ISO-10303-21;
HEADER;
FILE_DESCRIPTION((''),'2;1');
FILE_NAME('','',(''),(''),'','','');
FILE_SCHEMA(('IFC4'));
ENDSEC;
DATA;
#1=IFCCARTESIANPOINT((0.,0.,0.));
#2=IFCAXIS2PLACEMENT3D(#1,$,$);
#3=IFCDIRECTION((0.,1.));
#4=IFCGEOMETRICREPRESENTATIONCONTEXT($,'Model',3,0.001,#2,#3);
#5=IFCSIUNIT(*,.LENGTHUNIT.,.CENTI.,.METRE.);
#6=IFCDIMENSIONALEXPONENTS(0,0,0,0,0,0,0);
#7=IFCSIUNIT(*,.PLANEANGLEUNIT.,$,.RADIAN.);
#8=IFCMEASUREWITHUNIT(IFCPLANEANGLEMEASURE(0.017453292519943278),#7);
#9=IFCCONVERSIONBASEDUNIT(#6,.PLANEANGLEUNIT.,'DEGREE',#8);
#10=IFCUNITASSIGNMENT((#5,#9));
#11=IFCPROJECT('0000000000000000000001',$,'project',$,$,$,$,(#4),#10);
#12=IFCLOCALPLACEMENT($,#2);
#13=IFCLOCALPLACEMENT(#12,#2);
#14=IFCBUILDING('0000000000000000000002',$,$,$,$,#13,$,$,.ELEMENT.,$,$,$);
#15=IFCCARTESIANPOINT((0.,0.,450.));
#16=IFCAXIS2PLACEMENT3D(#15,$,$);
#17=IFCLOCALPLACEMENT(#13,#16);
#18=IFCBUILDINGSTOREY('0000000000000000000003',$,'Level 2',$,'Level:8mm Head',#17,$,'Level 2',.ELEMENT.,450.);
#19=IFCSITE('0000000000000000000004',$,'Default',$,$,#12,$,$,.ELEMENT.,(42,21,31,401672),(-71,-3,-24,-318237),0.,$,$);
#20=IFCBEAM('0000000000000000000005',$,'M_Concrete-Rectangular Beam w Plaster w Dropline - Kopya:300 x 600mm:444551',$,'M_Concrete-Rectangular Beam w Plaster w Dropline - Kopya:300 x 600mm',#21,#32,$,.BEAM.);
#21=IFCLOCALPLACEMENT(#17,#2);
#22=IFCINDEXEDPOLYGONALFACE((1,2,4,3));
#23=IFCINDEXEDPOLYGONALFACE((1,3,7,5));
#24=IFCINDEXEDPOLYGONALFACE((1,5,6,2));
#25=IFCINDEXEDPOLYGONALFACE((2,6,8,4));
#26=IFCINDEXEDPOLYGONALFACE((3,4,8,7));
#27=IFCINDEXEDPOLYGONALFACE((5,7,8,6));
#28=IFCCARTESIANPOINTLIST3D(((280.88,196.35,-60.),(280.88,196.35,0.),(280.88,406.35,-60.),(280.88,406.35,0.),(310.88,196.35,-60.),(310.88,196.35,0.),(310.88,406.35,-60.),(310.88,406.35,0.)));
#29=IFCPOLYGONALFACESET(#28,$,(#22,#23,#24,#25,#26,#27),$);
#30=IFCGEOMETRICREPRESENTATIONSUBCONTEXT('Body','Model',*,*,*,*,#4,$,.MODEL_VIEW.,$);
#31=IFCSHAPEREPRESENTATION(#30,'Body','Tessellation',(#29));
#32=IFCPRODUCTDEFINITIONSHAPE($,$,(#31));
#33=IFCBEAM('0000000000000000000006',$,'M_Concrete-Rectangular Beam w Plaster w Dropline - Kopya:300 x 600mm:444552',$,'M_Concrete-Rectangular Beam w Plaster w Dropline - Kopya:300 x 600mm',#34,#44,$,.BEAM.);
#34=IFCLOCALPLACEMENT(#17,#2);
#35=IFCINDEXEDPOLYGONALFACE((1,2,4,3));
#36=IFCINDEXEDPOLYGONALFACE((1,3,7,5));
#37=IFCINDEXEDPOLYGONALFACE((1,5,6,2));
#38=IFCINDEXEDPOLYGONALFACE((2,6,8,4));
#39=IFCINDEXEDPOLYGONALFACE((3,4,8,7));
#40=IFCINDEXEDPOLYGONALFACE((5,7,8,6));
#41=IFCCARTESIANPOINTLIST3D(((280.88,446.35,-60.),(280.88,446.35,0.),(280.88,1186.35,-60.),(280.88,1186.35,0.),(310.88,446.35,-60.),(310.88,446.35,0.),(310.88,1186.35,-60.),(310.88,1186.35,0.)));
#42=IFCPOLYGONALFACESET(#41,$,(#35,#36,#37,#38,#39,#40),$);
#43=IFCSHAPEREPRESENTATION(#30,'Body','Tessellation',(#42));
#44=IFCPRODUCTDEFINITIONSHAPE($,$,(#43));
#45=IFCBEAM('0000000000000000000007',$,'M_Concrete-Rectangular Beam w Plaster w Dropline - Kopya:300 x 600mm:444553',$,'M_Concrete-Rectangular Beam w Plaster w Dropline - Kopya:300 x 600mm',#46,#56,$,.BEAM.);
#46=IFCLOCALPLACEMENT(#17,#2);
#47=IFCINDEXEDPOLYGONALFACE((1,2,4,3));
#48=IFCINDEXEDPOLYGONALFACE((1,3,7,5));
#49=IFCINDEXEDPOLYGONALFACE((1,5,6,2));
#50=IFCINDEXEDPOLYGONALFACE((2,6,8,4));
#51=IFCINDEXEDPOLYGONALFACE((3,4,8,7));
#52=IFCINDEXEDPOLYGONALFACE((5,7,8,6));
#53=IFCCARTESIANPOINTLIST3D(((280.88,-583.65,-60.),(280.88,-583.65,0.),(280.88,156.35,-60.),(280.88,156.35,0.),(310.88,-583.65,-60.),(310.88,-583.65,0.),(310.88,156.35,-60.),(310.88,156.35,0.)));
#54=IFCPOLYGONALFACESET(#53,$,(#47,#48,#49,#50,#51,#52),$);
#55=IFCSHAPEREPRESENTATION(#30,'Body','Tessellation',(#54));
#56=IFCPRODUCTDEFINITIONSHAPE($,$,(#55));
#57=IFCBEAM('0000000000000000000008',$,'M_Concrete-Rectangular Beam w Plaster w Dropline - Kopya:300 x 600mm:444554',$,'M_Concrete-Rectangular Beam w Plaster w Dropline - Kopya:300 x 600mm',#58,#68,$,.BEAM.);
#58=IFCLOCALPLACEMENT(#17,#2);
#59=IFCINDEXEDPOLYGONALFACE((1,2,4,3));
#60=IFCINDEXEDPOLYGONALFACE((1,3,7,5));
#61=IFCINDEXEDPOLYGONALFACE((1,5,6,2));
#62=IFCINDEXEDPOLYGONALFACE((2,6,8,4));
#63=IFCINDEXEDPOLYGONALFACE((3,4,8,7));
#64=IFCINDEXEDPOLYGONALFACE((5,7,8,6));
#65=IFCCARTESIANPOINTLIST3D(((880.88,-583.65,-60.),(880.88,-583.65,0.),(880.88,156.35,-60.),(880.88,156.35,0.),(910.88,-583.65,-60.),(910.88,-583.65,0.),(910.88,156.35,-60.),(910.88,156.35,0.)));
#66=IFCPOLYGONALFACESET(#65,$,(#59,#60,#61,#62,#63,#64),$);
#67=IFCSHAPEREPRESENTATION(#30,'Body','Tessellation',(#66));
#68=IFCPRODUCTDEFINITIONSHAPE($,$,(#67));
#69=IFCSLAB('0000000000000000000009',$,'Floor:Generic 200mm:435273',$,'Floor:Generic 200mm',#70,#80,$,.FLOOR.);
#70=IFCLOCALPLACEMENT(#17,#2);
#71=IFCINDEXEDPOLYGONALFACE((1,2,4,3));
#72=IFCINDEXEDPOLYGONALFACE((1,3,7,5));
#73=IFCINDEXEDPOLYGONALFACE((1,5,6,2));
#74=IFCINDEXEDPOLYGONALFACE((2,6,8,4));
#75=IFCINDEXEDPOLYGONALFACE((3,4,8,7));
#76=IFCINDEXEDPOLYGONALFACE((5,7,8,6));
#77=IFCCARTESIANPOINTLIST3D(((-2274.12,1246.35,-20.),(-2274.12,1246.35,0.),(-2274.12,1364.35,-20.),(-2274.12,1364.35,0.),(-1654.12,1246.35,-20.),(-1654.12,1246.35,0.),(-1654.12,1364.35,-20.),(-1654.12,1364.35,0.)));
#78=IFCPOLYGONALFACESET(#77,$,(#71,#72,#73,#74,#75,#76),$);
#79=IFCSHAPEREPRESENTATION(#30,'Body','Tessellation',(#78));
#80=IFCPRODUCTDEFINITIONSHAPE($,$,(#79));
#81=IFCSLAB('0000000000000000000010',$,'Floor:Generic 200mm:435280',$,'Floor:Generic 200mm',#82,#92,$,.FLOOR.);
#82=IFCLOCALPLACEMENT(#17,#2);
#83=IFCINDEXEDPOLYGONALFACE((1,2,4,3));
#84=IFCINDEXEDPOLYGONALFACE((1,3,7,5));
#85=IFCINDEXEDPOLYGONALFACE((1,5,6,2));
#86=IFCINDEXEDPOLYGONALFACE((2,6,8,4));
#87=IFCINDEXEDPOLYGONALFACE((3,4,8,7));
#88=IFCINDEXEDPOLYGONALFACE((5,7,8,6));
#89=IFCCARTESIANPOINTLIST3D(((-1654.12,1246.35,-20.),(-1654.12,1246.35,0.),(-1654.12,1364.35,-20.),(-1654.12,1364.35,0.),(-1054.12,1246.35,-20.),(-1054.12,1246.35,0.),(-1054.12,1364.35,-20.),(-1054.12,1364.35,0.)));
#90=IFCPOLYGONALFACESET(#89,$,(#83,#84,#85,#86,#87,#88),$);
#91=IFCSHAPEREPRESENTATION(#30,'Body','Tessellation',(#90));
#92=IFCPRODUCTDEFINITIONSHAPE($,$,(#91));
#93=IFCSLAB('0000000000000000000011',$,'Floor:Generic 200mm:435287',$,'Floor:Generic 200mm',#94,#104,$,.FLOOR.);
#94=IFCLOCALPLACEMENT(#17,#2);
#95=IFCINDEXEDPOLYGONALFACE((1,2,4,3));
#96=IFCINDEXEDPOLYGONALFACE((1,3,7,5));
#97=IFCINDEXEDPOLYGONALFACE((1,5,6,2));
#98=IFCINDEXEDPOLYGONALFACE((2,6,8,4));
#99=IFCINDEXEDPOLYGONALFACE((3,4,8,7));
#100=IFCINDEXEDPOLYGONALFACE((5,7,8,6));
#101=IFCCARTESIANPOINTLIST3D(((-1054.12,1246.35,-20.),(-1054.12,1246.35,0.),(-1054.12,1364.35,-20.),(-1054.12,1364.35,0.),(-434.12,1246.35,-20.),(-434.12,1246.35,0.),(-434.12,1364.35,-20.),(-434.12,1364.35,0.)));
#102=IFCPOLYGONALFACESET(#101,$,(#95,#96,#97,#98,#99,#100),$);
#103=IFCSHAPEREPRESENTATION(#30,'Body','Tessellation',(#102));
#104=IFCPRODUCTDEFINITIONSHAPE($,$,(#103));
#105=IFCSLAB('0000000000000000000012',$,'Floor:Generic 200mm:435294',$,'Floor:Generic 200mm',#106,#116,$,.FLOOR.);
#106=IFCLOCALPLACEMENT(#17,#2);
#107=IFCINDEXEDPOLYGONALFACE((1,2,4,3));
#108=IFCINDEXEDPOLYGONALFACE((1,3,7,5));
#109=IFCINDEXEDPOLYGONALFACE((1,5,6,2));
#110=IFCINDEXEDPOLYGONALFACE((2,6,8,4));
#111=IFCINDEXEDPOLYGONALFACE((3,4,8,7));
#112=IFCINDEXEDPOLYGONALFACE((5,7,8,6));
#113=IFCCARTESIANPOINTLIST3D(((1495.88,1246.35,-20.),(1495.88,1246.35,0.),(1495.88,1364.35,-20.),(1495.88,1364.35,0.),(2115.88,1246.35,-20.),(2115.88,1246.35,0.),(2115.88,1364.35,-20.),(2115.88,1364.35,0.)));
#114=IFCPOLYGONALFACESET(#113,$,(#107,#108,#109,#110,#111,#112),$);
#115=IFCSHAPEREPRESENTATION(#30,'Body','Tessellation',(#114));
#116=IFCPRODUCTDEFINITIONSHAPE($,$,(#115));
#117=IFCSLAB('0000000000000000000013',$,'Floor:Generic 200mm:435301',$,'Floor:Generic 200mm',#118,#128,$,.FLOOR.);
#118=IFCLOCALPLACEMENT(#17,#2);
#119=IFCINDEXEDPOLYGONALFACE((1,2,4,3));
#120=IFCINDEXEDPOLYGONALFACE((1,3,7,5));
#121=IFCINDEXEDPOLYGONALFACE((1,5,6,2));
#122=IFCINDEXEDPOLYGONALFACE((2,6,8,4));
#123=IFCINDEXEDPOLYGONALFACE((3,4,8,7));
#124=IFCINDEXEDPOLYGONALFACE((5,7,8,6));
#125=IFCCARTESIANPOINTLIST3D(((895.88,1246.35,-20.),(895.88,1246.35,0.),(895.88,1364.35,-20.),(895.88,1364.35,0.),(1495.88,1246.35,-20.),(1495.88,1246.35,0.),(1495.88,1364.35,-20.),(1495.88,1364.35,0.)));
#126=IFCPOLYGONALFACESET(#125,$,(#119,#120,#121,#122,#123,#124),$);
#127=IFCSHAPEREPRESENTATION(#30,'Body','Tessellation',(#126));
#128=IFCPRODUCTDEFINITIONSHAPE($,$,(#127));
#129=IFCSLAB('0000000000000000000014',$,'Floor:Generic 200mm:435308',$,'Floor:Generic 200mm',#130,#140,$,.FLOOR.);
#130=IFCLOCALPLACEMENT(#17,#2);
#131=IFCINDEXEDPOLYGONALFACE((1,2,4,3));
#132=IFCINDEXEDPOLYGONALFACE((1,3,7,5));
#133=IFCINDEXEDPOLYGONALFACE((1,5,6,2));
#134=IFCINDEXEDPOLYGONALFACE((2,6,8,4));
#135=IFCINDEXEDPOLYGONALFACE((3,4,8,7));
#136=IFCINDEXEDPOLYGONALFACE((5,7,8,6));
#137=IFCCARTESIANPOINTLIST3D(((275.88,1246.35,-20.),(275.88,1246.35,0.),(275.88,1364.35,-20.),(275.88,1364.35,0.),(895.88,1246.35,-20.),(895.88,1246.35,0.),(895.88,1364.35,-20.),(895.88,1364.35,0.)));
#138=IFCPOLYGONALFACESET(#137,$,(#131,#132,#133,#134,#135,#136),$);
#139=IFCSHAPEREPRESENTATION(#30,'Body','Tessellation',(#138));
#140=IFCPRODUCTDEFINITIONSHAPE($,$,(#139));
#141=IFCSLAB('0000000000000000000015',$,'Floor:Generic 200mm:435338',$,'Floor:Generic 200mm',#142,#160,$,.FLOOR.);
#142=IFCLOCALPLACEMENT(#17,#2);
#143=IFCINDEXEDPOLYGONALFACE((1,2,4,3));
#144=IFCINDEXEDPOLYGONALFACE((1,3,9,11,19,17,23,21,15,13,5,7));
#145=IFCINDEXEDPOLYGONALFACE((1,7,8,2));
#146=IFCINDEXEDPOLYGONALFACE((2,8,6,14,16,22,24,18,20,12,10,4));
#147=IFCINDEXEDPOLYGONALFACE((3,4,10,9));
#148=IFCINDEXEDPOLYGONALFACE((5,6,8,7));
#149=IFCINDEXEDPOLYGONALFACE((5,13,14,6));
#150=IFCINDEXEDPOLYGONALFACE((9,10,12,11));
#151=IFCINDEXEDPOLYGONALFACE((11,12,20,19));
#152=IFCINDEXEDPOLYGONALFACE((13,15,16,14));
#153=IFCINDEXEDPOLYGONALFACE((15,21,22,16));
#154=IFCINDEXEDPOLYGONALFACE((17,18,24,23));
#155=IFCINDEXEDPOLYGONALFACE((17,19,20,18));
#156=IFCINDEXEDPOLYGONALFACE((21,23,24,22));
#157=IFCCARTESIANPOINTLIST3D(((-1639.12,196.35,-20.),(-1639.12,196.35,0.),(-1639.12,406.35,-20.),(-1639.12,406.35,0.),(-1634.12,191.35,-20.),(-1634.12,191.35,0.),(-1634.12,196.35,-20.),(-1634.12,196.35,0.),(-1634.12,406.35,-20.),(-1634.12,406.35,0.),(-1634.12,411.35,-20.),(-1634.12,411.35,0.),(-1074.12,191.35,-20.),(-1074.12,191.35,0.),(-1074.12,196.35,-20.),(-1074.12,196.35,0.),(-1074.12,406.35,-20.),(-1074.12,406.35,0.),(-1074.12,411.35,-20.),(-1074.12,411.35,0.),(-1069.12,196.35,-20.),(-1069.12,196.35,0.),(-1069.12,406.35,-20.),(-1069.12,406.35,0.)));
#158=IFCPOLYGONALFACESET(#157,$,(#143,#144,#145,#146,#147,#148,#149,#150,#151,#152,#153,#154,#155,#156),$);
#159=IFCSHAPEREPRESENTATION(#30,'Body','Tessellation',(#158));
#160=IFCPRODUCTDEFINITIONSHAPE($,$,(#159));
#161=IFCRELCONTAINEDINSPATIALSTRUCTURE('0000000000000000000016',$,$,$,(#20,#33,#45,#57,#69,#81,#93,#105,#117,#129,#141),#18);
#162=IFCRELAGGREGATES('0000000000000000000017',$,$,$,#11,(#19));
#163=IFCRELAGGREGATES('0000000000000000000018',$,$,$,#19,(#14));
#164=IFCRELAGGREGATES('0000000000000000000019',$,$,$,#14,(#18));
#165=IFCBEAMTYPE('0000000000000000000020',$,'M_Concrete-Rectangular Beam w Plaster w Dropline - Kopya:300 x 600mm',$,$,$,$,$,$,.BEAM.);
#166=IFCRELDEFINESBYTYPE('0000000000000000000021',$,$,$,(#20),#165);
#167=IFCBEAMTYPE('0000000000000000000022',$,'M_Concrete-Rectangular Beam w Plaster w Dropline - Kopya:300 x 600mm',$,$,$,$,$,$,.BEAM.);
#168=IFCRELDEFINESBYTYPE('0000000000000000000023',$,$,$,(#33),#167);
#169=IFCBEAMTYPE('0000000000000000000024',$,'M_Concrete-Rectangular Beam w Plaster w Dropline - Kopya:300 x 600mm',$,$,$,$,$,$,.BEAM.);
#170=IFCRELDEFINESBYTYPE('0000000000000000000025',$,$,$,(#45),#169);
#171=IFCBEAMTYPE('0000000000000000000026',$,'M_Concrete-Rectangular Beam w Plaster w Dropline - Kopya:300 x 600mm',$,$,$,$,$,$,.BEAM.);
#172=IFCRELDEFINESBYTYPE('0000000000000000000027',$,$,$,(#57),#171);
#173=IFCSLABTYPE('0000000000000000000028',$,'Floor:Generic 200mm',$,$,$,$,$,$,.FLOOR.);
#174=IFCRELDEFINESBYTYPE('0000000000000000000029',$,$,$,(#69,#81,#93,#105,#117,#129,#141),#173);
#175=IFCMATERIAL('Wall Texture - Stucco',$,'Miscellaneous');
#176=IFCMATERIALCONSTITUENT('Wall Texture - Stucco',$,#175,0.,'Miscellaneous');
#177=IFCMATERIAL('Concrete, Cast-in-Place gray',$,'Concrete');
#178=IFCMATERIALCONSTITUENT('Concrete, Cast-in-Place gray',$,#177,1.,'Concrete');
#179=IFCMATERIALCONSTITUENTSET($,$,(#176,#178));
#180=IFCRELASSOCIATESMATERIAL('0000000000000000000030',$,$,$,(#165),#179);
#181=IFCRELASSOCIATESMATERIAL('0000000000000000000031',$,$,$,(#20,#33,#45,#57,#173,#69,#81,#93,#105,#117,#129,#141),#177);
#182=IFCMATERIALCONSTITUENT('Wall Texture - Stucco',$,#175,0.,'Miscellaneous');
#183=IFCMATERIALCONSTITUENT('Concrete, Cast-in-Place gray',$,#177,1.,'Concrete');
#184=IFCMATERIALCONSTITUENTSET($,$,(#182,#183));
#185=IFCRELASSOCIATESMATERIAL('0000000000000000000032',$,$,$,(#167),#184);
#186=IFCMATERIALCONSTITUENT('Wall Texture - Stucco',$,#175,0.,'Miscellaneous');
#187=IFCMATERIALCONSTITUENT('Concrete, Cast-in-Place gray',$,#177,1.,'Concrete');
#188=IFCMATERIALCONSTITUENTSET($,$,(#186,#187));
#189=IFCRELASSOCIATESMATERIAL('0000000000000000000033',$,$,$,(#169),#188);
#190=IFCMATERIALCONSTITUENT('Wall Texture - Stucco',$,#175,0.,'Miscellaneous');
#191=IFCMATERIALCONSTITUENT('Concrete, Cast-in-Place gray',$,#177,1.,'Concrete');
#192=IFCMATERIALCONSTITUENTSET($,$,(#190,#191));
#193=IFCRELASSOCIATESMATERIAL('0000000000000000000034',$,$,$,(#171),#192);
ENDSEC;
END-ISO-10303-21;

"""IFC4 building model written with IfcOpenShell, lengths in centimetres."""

from ifc_helpers import new_model, entity, si_unit, converted_unit, direction, frame, origin, place, context, subcontext, project, spatial, indexed_curve, outline, extrude, source, transform, mapped, material, constituent, constituent_set, type_object, type_shapes, element, save


model = new_model("IFC4")

# Units and contexts
model_context = context("Model", 3, precision=0.001, world=origin(), true_north=direction((0.0, 1.0)))
body_context = subcontext(model_context, "Body", "Model", "MODEL_VIEW")
ifc_project = project(units=[si_unit("LENGTHUNIT", "METRE", prefix="CENTI"), converted_unit("PLANEANGLEUNIT", "DEGREE", entity("IfcPlaneAngleMeasure", 0.017453292519943278), si_unit("PLANEANGLEUNIT", "RADIAN"), dimensions=[0, 0, 0, 0, 0, 0, 0])], contexts=[model_context])

# Site, building, storey
site_placement = place(None, origin())
site = spatial("IfcSite", under=ifc_project, at=site_placement, Name="Default", CompositionType="ELEMENT", RefLatitude=(42, 21, 31, 401672), RefLongitude=(-71, -3, -24, -318237), RefElevation=0.0)
building_placement = place(site_placement, origin())
building = spatial("IfcBuilding", under=site, at=building_placement, CompositionType="ELEMENT")
storey_placement = place(building_placement, frame((0.0, 0.0, 450.0)))
storey = spatial("IfcBuildingStorey", under=building, at=storey_placement, Name="Level 2", ObjectType="Level:8mm Head", LongName="Level 2", CompositionType="ELEMENT", Elevation=450.0)

# Beams
ifc_material_1 = material(Name="Concrete, Cast-in-Place gray", Category="Concrete")
ifc_material_2 = material(Name="Wall Texture - Stucco", Category="Miscellaneous")
ifc_constituent_1 = constituent(ifc_material_2, Name="Wall Texture - Stucco", Category="Miscellaneous", fraction=0.0)
ifc_constituent_2 = constituent(ifc_material_1, Name="Concrete, Cast-in-Place gray", Category="Concrete", fraction=1.0)
ifc_constituent_set_1 = constituent_set(constituents=[ifc_constituent_1, ifc_constituent_2])
beam_type_1 = type_object("IfcBeamType", Name="M_Concrete-Rectangular Beam w Plaster w Dropline - Kopya:300 x 600mm", PredefinedType="BEAM", material=ifc_constituent_set_1)
shared_shape_1 = source(origin(), body_context, "Body", "SweptSolid", [
    extrude(outline(indexed_curve([(-15.0, -30.0), (15.0, -30.0), (15.0, 30.0), (-15.0, 30.0), (-15.0, -30.0)], self_intersect=False)), frame((295.88, 406.35, 420.0), z_axis=(0.0, -1.0, 0.0), x_axis=(-1.0, 0.0, 0.0)), (0.0, 0.0, 1.0), 210.0),
])
type_shapes(beam_type_1, [shared_shape_1])
beam_1_placement = place(storey_placement, frame((0.0, 0.0, -450.0)))
element("IfcBeam", 1, at=beam_1_placement, inside=storey, type_object=beam_type_1, material=ifc_material_1, Name="M_Concrete-Rectangular Beam w Plaster w Dropline - Kopya:300 x 600mm:444551", ObjectType="M_Concrete-Rectangular Beam w Plaster w Dropline - Kopya:300 x 600mm", PredefinedType="BEAM", context=body_context, shape_type="MappedRepresentation", body=[
    mapped(shared_shape_1, transform((0.0, 0.0, 0.0), scale=1.0)),
])
ifc_constituent_3 = constituent(ifc_material_2, Name="Wall Texture - Stucco", Category="Miscellaneous", fraction=0.0)
ifc_constituent_4 = constituent(ifc_material_1, Name="Concrete, Cast-in-Place gray", Category="Concrete", fraction=1.0)
ifc_constituent_set_2 = constituent_set(constituents=[ifc_constituent_3, ifc_constituent_4])
beam_type_2 = type_object("IfcBeamType", Name="M_Concrete-Rectangular Beam w Plaster w Dropline - Kopya:300 x 600mm", PredefinedType="BEAM", material=ifc_constituent_set_2)
shared_shape_2 = source(origin(), body_context, "Body", "SweptSolid", [
    extrude(outline(indexed_curve([(-15.0, -30.0), (15.0, -30.0), (15.0, 30.0), (-15.0, 30.0), (-15.0, -30.0)], self_intersect=False)), frame((295.88, 446.35, 420.0), z_axis=(0.0, 1.0, 0.0), x_axis=(-1.0, 0.0, 0.0)), (0.0, 0.0, 1.0), 740.0),
])
type_shapes(beam_type_2, [shared_shape_2])
beam_2_placement = place(storey_placement, frame((0.0, 0.0, -450.0)))
element("IfcBeam", 2, at=beam_2_placement, inside=storey, type_object=beam_type_2, material=ifc_material_1, Name="M_Concrete-Rectangular Beam w Plaster w Dropline - Kopya:300 x 600mm:444552", ObjectType="M_Concrete-Rectangular Beam w Plaster w Dropline - Kopya:300 x 600mm", PredefinedType="BEAM", context=body_context, shape_type="MappedRepresentation", body=[
    mapped(shared_shape_2, transform((0.0, 0.0, 0.0), scale=1.0)),
])
ifc_constituent_5 = constituent(ifc_material_2, Name="Wall Texture - Stucco", Category="Miscellaneous", fraction=0.0)
ifc_constituent_6 = constituent(ifc_material_1, Name="Concrete, Cast-in-Place gray", Category="Concrete", fraction=1.0)
ifc_constituent_set_3 = constituent_set(constituents=[ifc_constituent_5, ifc_constituent_6])
beam_type_3 = type_object("IfcBeamType", Name="M_Concrete-Rectangular Beam w Plaster w Dropline - Kopya:300 x 600mm", PredefinedType="BEAM", material=ifc_constituent_set_3)
shared_shape_3 = source(origin(), body_context, "Body", "SweptSolid", [
    extrude(outline(indexed_curve([(-15.0, -30.0), (15.0, -30.0), (15.0, 30.0), (-15.0, 30.0), (-15.0, -30.0)], self_intersect=False)), frame((295.88, 156.35, 420.0), z_axis=(0.0, -1.0, 0.0), x_axis=(-1.0, 0.0, 0.0)), (0.0, 0.0, 1.0), 740.0),
])
type_shapes(beam_type_3, [shared_shape_3])
beam_3_placement = place(storey_placement, frame((0.0, 0.0, -450.0)))
element("IfcBeam", 3, at=beam_3_placement, inside=storey, type_object=beam_type_3, material=ifc_material_1, Name="M_Concrete-Rectangular Beam w Plaster w Dropline - Kopya:300 x 600mm:444553", ObjectType="M_Concrete-Rectangular Beam w Plaster w Dropline - Kopya:300 x 600mm", PredefinedType="BEAM", context=body_context, shape_type="MappedRepresentation", body=[
    mapped(shared_shape_3, transform((0.0, 0.0, 0.0), scale=1.0)),
])
ifc_constituent_7 = constituent(ifc_material_2, Name="Wall Texture - Stucco", Category="Miscellaneous", fraction=0.0)
ifc_constituent_8 = constituent(ifc_material_1, Name="Concrete, Cast-in-Place gray", Category="Concrete", fraction=1.0)
ifc_constituent_set_4 = constituent_set(constituents=[ifc_constituent_7, ifc_constituent_8])
beam_type_4 = type_object("IfcBeamType", Name="M_Concrete-Rectangular Beam w Plaster w Dropline - Kopya:300 x 600mm", PredefinedType="BEAM", material=ifc_constituent_set_4)
shared_shape_4 = source(origin(), body_context, "Body", "SweptSolid", [
    extrude(outline(indexed_curve([(-15.0, -30.0), (15.0, -30.0), (15.0, 30.0), (-15.0, 30.0), (-15.0, -30.0)], self_intersect=False)), frame((895.88, -583.65, 420.0), z_axis=(0.0, 1.0, 0.0), x_axis=(-1.0, 0.0, 0.0)), (0.0, 0.0, 1.0), 740.0),
])
type_shapes(beam_type_4, [shared_shape_4])
beam_4_placement = place(storey_placement, frame((0.0, 0.0, -450.0)))
element("IfcBeam", 4, at=beam_4_placement, inside=storey, type_object=beam_type_4, material=ifc_material_1, Name="M_Concrete-Rectangular Beam w Plaster w Dropline - Kopya:300 x 600mm:444554", ObjectType="M_Concrete-Rectangular Beam w Plaster w Dropline - Kopya:300 x 600mm", PredefinedType="BEAM", context=body_context, shape_type="MappedRepresentation", body=[
    mapped(shared_shape_4, transform((0.0, 0.0, 0.0), scale=1.0)),
])

# Shared definitions
slab_type = type_object("IfcSlabType", Name="Floor:Generic 200mm", PredefinedType="FLOOR", material=ifc_material_1)

# Slabs
slab_1_placement = place(storey_placement, origin())
element("IfcSlab", 5, at=slab_1_placement, inside=storey, type_object=slab_type, material=ifc_material_1, Name="Floor:Generic 200mm:435273", ObjectType="Floor:Generic 200mm", PredefinedType="FLOOR", context=body_context, shape_type="SweptSolid", body=[
    extrude(outline(indexed_curve([(-59.0, -310.0), (59.0, -310.0), (59.0, 310.0), (-59.0, 310.0), (-59.0, -310.0)], self_intersect=False)), frame((-1964.12, 1305.35, 0.0), z_axis=(0.0, 0.0, -1.0), x_axis=(0.0, 1.0, 0.0)), (0.0, 0.0, 1.0), 20.0),
])
slab_2_placement = place(storey_placement, origin())
element("IfcSlab", 6, at=slab_2_placement, inside=storey, type_object=slab_type, material=ifc_material_1, Name="Floor:Generic 200mm:435280", ObjectType="Floor:Generic 200mm", PredefinedType="FLOOR", context=body_context, shape_type="SweptSolid", body=[
    extrude(outline(indexed_curve([(-59.0, -300.0), (59.0, -300.0), (59.0, 300.0), (-59.0, 300.0), (-59.0, -300.0)], self_intersect=False)), frame((-1354.12, 1305.35, 0.0), z_axis=(0.0, 0.0, -1.0), x_axis=(0.0, 1.0, 0.0)), (0.0, 0.0, 1.0), 20.0),
])
slab_3_placement = place(storey_placement, origin())
element("IfcSlab", 7, at=slab_3_placement, inside=storey, type_object=slab_type, material=ifc_material_1, Name="Floor:Generic 200mm:435287", ObjectType="Floor:Generic 200mm", PredefinedType="FLOOR", context=body_context, shape_type="SweptSolid", body=[
    extrude(outline(indexed_curve([(-59.0, -310.0), (59.0, -310.0), (59.0, 310.0), (-59.0, 310.0), (-59.0, -310.0)], self_intersect=False)), frame((-744.12, 1305.35, 0.0), z_axis=(0.0, 0.0, -1.0), x_axis=(0.0, 1.0, 0.0)), (0.0, 0.0, 1.0), 20.0),
])
slab_4_placement = place(storey_placement, origin())
element("IfcSlab", 8, at=slab_4_placement, inside=storey, type_object=slab_type, material=ifc_material_1, Name="Floor:Generic 200mm:435294", ObjectType="Floor:Generic 200mm", PredefinedType="FLOOR", context=body_context, shape_type="SweptSolid", body=[
    extrude(outline(indexed_curve([(-59.0, -310.0), (59.0, -310.0), (59.0, 310.0), (-59.0, 310.0), (-59.0, -310.0)], self_intersect=False)), frame((1805.88, 1305.35, 0.0), z_axis=(0.0, 0.0, -1.0), x_axis=(0.0, 1.0, 0.0)), (0.0, 0.0, 1.0), 20.0),
])
slab_5_placement = place(storey_placement, origin())
element("IfcSlab", 9, at=slab_5_placement, inside=storey, type_object=slab_type, material=ifc_material_1, Name="Floor:Generic 200mm:435301", ObjectType="Floor:Generic 200mm", PredefinedType="FLOOR", context=body_context, shape_type="SweptSolid", body=[
    extrude(outline(indexed_curve([(-59.0, -300.0), (59.0, -300.0), (59.0, 300.0), (-59.0, 300.0), (-59.0, -300.0)], self_intersect=False)), frame((1195.88, 1305.35, 0.0), z_axis=(0.0, 0.0, -1.0), x_axis=(0.0, 1.0, 0.0)), (0.0, 0.0, 1.0), 20.0),
])
slab_6_placement = place(storey_placement, origin())
element("IfcSlab", 10, at=slab_6_placement, inside=storey, type_object=slab_type, material=ifc_material_1, Name="Floor:Generic 200mm:435308", ObjectType="Floor:Generic 200mm", PredefinedType="FLOOR", context=body_context, shape_type="SweptSolid", body=[
    extrude(outline(indexed_curve([(-59.0, -310.0), (59.0, -310.0), (59.0, 310.0), (-59.0, 310.0), (-59.0, -310.0)], self_intersect=False)), frame((585.88, 1305.35, 0.0), z_axis=(0.0, 0.0, -1.0), x_axis=(0.0, 1.0, 0.0)), (0.0, 0.0, 1.0), 20.0),
])
slab_7_placement = place(storey_placement, origin())
element("IfcSlab", 11, at=slab_7_placement, inside=storey, type_object=slab_type, material=ifc_material_1, Name="Floor:Generic 200mm:435338", ObjectType="Floor:Generic 200mm", PredefinedType="FLOOR", context=body_context, shape_type="SweptSolid", body=[
    extrude(outline(indexed_curve([(-105.0, -285.0), (105.0, -285.0), (105.0, -280.0), (110.0, -280.0), (110.0, 280.0), (105.0, 280.0), (105.0, 285.0), (-105.0, 285.0), (-105.0, 280.0), (-110.0, 280.0), (-110.0, -280.0), (-105.0, -280.0), (-105.0, -285.0)], self_intersect=False)), frame((-1354.12, 301.35, 0.0), z_axis=(0.0, 0.0, -1.0), x_axis=(0.0, 1.0, 0.0)), (0.0, 0.0, 1.0), 20.0),
])

save(model, "model.ifc")
